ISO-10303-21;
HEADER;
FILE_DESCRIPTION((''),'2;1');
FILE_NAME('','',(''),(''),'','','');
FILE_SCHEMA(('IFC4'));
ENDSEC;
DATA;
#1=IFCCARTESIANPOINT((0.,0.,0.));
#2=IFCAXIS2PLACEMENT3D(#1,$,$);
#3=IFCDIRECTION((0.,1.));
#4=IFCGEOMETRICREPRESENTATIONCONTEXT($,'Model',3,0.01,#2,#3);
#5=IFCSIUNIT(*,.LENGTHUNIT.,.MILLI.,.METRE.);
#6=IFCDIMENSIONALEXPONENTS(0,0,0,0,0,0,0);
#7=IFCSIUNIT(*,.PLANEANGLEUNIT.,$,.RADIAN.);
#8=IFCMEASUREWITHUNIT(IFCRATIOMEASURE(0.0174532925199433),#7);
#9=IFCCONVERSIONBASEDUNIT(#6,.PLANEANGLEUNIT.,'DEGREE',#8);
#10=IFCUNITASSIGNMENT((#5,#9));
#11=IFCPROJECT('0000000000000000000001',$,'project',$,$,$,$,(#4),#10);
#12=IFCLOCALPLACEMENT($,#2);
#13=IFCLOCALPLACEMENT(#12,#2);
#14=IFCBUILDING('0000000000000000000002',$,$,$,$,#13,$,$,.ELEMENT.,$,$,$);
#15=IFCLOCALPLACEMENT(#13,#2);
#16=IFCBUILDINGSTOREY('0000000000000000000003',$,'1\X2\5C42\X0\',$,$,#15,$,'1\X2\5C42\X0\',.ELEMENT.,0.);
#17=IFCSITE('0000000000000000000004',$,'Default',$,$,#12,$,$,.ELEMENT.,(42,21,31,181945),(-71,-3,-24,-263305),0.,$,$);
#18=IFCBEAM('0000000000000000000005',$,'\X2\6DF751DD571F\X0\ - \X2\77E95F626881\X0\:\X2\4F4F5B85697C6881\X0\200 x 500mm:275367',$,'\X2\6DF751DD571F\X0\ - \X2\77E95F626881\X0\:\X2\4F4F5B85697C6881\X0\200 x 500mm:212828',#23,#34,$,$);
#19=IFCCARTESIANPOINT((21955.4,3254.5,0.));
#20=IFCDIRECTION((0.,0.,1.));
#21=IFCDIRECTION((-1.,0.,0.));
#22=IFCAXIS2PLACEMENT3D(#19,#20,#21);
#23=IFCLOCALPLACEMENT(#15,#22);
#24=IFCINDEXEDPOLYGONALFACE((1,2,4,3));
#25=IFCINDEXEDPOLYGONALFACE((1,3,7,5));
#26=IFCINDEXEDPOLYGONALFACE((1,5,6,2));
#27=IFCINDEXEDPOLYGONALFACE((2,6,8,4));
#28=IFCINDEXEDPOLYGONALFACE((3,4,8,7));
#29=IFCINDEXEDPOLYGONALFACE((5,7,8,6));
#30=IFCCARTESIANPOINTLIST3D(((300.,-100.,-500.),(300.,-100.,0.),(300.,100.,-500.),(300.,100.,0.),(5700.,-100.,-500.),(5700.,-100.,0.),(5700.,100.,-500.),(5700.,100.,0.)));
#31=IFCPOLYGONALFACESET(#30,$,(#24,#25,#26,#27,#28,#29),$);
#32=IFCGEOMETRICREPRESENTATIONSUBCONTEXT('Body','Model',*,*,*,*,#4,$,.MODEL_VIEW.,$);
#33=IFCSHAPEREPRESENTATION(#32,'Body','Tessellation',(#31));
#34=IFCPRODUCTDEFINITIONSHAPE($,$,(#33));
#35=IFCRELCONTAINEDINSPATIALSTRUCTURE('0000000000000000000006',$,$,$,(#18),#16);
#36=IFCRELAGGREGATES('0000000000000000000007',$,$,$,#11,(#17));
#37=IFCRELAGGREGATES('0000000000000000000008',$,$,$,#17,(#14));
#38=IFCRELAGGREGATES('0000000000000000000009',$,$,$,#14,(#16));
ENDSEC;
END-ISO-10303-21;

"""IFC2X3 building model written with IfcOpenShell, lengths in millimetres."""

from ifc_helpers import new_model, entity, si_unit, converted_unit, direction, frame, frame_2d, origin, place, context, subcontext, project, spatial, rectangle, extrude, element, save


model = new_model("IFC2X3")

# Units and contexts
model_context = context("Model", 3, precision=0.01, world=origin(), true_north=direction((0.0, 1.0)))
body_context = subcontext(model_context, "Body", "Model", "MODEL_VIEW")
ifc_project = project(units=[si_unit("LENGTHUNIT", "METRE", prefix="MILLI"), converted_unit("PLANEANGLEUNIT", "DEGREE", entity("IfcRatioMeasure", 0.0174532925199433), si_unit("PLANEANGLEUNIT", "RADIAN"), dimensions=[0, 0, 0, 0, 0, 0, 0])], contexts=[model_context])

# Site, building, storey
site_placement = place(None, origin())
site = spatial("IfcSite", under=ifc_project, at=site_placement, Name="Default", CompositionType="ELEMENT", RefLatitude=(42, 21, 31, 181945), RefLongitude=(-71, -3, -24, -263305), RefElevation=0.0)
building_placement = place(site_placement, origin())
building = spatial("IfcBuilding", under=site, at=building_placement, CompositionType="ELEMENT")
storey_placement = place(building_placement, origin())
storey = spatial("IfcBuildingStorey", under=building, at=storey_placement, Name="1层", LongName="1层", CompositionType="ELEMENT", Elevation=0.0)

# Beam
beam_1_placement = place(storey_placement, frame((21955.4, 3254.5, 0.0), z_axis=(0.0, 0.0, 1.0), x_axis=(-1.0, 0.0, 0.0)))
element("IfcBeam", 1, at=beam_1_placement, inside=storey, Name="混凝土 - 矩形梁:住宅楼梁200 x 500mm:275367", ObjectType="混凝土 - 矩形梁:住宅楼梁200 x 500mm:212828", context=body_context, shape_type="SweptSolid", body=[
    extrude(rectangle(XDim=500.0, YDim=200.0, at=frame_2d((0.0, 0.0), x_axis=(1.0, 0.0))), frame((300.0, 0.0, -250.0), z_axis=(1.0, 0.0, 0.0), x_axis=(0.0, 0.0, -1.0)), (0.0, 0.0, 1.0), 5400.0),
])

save(model, "model.ifc")
